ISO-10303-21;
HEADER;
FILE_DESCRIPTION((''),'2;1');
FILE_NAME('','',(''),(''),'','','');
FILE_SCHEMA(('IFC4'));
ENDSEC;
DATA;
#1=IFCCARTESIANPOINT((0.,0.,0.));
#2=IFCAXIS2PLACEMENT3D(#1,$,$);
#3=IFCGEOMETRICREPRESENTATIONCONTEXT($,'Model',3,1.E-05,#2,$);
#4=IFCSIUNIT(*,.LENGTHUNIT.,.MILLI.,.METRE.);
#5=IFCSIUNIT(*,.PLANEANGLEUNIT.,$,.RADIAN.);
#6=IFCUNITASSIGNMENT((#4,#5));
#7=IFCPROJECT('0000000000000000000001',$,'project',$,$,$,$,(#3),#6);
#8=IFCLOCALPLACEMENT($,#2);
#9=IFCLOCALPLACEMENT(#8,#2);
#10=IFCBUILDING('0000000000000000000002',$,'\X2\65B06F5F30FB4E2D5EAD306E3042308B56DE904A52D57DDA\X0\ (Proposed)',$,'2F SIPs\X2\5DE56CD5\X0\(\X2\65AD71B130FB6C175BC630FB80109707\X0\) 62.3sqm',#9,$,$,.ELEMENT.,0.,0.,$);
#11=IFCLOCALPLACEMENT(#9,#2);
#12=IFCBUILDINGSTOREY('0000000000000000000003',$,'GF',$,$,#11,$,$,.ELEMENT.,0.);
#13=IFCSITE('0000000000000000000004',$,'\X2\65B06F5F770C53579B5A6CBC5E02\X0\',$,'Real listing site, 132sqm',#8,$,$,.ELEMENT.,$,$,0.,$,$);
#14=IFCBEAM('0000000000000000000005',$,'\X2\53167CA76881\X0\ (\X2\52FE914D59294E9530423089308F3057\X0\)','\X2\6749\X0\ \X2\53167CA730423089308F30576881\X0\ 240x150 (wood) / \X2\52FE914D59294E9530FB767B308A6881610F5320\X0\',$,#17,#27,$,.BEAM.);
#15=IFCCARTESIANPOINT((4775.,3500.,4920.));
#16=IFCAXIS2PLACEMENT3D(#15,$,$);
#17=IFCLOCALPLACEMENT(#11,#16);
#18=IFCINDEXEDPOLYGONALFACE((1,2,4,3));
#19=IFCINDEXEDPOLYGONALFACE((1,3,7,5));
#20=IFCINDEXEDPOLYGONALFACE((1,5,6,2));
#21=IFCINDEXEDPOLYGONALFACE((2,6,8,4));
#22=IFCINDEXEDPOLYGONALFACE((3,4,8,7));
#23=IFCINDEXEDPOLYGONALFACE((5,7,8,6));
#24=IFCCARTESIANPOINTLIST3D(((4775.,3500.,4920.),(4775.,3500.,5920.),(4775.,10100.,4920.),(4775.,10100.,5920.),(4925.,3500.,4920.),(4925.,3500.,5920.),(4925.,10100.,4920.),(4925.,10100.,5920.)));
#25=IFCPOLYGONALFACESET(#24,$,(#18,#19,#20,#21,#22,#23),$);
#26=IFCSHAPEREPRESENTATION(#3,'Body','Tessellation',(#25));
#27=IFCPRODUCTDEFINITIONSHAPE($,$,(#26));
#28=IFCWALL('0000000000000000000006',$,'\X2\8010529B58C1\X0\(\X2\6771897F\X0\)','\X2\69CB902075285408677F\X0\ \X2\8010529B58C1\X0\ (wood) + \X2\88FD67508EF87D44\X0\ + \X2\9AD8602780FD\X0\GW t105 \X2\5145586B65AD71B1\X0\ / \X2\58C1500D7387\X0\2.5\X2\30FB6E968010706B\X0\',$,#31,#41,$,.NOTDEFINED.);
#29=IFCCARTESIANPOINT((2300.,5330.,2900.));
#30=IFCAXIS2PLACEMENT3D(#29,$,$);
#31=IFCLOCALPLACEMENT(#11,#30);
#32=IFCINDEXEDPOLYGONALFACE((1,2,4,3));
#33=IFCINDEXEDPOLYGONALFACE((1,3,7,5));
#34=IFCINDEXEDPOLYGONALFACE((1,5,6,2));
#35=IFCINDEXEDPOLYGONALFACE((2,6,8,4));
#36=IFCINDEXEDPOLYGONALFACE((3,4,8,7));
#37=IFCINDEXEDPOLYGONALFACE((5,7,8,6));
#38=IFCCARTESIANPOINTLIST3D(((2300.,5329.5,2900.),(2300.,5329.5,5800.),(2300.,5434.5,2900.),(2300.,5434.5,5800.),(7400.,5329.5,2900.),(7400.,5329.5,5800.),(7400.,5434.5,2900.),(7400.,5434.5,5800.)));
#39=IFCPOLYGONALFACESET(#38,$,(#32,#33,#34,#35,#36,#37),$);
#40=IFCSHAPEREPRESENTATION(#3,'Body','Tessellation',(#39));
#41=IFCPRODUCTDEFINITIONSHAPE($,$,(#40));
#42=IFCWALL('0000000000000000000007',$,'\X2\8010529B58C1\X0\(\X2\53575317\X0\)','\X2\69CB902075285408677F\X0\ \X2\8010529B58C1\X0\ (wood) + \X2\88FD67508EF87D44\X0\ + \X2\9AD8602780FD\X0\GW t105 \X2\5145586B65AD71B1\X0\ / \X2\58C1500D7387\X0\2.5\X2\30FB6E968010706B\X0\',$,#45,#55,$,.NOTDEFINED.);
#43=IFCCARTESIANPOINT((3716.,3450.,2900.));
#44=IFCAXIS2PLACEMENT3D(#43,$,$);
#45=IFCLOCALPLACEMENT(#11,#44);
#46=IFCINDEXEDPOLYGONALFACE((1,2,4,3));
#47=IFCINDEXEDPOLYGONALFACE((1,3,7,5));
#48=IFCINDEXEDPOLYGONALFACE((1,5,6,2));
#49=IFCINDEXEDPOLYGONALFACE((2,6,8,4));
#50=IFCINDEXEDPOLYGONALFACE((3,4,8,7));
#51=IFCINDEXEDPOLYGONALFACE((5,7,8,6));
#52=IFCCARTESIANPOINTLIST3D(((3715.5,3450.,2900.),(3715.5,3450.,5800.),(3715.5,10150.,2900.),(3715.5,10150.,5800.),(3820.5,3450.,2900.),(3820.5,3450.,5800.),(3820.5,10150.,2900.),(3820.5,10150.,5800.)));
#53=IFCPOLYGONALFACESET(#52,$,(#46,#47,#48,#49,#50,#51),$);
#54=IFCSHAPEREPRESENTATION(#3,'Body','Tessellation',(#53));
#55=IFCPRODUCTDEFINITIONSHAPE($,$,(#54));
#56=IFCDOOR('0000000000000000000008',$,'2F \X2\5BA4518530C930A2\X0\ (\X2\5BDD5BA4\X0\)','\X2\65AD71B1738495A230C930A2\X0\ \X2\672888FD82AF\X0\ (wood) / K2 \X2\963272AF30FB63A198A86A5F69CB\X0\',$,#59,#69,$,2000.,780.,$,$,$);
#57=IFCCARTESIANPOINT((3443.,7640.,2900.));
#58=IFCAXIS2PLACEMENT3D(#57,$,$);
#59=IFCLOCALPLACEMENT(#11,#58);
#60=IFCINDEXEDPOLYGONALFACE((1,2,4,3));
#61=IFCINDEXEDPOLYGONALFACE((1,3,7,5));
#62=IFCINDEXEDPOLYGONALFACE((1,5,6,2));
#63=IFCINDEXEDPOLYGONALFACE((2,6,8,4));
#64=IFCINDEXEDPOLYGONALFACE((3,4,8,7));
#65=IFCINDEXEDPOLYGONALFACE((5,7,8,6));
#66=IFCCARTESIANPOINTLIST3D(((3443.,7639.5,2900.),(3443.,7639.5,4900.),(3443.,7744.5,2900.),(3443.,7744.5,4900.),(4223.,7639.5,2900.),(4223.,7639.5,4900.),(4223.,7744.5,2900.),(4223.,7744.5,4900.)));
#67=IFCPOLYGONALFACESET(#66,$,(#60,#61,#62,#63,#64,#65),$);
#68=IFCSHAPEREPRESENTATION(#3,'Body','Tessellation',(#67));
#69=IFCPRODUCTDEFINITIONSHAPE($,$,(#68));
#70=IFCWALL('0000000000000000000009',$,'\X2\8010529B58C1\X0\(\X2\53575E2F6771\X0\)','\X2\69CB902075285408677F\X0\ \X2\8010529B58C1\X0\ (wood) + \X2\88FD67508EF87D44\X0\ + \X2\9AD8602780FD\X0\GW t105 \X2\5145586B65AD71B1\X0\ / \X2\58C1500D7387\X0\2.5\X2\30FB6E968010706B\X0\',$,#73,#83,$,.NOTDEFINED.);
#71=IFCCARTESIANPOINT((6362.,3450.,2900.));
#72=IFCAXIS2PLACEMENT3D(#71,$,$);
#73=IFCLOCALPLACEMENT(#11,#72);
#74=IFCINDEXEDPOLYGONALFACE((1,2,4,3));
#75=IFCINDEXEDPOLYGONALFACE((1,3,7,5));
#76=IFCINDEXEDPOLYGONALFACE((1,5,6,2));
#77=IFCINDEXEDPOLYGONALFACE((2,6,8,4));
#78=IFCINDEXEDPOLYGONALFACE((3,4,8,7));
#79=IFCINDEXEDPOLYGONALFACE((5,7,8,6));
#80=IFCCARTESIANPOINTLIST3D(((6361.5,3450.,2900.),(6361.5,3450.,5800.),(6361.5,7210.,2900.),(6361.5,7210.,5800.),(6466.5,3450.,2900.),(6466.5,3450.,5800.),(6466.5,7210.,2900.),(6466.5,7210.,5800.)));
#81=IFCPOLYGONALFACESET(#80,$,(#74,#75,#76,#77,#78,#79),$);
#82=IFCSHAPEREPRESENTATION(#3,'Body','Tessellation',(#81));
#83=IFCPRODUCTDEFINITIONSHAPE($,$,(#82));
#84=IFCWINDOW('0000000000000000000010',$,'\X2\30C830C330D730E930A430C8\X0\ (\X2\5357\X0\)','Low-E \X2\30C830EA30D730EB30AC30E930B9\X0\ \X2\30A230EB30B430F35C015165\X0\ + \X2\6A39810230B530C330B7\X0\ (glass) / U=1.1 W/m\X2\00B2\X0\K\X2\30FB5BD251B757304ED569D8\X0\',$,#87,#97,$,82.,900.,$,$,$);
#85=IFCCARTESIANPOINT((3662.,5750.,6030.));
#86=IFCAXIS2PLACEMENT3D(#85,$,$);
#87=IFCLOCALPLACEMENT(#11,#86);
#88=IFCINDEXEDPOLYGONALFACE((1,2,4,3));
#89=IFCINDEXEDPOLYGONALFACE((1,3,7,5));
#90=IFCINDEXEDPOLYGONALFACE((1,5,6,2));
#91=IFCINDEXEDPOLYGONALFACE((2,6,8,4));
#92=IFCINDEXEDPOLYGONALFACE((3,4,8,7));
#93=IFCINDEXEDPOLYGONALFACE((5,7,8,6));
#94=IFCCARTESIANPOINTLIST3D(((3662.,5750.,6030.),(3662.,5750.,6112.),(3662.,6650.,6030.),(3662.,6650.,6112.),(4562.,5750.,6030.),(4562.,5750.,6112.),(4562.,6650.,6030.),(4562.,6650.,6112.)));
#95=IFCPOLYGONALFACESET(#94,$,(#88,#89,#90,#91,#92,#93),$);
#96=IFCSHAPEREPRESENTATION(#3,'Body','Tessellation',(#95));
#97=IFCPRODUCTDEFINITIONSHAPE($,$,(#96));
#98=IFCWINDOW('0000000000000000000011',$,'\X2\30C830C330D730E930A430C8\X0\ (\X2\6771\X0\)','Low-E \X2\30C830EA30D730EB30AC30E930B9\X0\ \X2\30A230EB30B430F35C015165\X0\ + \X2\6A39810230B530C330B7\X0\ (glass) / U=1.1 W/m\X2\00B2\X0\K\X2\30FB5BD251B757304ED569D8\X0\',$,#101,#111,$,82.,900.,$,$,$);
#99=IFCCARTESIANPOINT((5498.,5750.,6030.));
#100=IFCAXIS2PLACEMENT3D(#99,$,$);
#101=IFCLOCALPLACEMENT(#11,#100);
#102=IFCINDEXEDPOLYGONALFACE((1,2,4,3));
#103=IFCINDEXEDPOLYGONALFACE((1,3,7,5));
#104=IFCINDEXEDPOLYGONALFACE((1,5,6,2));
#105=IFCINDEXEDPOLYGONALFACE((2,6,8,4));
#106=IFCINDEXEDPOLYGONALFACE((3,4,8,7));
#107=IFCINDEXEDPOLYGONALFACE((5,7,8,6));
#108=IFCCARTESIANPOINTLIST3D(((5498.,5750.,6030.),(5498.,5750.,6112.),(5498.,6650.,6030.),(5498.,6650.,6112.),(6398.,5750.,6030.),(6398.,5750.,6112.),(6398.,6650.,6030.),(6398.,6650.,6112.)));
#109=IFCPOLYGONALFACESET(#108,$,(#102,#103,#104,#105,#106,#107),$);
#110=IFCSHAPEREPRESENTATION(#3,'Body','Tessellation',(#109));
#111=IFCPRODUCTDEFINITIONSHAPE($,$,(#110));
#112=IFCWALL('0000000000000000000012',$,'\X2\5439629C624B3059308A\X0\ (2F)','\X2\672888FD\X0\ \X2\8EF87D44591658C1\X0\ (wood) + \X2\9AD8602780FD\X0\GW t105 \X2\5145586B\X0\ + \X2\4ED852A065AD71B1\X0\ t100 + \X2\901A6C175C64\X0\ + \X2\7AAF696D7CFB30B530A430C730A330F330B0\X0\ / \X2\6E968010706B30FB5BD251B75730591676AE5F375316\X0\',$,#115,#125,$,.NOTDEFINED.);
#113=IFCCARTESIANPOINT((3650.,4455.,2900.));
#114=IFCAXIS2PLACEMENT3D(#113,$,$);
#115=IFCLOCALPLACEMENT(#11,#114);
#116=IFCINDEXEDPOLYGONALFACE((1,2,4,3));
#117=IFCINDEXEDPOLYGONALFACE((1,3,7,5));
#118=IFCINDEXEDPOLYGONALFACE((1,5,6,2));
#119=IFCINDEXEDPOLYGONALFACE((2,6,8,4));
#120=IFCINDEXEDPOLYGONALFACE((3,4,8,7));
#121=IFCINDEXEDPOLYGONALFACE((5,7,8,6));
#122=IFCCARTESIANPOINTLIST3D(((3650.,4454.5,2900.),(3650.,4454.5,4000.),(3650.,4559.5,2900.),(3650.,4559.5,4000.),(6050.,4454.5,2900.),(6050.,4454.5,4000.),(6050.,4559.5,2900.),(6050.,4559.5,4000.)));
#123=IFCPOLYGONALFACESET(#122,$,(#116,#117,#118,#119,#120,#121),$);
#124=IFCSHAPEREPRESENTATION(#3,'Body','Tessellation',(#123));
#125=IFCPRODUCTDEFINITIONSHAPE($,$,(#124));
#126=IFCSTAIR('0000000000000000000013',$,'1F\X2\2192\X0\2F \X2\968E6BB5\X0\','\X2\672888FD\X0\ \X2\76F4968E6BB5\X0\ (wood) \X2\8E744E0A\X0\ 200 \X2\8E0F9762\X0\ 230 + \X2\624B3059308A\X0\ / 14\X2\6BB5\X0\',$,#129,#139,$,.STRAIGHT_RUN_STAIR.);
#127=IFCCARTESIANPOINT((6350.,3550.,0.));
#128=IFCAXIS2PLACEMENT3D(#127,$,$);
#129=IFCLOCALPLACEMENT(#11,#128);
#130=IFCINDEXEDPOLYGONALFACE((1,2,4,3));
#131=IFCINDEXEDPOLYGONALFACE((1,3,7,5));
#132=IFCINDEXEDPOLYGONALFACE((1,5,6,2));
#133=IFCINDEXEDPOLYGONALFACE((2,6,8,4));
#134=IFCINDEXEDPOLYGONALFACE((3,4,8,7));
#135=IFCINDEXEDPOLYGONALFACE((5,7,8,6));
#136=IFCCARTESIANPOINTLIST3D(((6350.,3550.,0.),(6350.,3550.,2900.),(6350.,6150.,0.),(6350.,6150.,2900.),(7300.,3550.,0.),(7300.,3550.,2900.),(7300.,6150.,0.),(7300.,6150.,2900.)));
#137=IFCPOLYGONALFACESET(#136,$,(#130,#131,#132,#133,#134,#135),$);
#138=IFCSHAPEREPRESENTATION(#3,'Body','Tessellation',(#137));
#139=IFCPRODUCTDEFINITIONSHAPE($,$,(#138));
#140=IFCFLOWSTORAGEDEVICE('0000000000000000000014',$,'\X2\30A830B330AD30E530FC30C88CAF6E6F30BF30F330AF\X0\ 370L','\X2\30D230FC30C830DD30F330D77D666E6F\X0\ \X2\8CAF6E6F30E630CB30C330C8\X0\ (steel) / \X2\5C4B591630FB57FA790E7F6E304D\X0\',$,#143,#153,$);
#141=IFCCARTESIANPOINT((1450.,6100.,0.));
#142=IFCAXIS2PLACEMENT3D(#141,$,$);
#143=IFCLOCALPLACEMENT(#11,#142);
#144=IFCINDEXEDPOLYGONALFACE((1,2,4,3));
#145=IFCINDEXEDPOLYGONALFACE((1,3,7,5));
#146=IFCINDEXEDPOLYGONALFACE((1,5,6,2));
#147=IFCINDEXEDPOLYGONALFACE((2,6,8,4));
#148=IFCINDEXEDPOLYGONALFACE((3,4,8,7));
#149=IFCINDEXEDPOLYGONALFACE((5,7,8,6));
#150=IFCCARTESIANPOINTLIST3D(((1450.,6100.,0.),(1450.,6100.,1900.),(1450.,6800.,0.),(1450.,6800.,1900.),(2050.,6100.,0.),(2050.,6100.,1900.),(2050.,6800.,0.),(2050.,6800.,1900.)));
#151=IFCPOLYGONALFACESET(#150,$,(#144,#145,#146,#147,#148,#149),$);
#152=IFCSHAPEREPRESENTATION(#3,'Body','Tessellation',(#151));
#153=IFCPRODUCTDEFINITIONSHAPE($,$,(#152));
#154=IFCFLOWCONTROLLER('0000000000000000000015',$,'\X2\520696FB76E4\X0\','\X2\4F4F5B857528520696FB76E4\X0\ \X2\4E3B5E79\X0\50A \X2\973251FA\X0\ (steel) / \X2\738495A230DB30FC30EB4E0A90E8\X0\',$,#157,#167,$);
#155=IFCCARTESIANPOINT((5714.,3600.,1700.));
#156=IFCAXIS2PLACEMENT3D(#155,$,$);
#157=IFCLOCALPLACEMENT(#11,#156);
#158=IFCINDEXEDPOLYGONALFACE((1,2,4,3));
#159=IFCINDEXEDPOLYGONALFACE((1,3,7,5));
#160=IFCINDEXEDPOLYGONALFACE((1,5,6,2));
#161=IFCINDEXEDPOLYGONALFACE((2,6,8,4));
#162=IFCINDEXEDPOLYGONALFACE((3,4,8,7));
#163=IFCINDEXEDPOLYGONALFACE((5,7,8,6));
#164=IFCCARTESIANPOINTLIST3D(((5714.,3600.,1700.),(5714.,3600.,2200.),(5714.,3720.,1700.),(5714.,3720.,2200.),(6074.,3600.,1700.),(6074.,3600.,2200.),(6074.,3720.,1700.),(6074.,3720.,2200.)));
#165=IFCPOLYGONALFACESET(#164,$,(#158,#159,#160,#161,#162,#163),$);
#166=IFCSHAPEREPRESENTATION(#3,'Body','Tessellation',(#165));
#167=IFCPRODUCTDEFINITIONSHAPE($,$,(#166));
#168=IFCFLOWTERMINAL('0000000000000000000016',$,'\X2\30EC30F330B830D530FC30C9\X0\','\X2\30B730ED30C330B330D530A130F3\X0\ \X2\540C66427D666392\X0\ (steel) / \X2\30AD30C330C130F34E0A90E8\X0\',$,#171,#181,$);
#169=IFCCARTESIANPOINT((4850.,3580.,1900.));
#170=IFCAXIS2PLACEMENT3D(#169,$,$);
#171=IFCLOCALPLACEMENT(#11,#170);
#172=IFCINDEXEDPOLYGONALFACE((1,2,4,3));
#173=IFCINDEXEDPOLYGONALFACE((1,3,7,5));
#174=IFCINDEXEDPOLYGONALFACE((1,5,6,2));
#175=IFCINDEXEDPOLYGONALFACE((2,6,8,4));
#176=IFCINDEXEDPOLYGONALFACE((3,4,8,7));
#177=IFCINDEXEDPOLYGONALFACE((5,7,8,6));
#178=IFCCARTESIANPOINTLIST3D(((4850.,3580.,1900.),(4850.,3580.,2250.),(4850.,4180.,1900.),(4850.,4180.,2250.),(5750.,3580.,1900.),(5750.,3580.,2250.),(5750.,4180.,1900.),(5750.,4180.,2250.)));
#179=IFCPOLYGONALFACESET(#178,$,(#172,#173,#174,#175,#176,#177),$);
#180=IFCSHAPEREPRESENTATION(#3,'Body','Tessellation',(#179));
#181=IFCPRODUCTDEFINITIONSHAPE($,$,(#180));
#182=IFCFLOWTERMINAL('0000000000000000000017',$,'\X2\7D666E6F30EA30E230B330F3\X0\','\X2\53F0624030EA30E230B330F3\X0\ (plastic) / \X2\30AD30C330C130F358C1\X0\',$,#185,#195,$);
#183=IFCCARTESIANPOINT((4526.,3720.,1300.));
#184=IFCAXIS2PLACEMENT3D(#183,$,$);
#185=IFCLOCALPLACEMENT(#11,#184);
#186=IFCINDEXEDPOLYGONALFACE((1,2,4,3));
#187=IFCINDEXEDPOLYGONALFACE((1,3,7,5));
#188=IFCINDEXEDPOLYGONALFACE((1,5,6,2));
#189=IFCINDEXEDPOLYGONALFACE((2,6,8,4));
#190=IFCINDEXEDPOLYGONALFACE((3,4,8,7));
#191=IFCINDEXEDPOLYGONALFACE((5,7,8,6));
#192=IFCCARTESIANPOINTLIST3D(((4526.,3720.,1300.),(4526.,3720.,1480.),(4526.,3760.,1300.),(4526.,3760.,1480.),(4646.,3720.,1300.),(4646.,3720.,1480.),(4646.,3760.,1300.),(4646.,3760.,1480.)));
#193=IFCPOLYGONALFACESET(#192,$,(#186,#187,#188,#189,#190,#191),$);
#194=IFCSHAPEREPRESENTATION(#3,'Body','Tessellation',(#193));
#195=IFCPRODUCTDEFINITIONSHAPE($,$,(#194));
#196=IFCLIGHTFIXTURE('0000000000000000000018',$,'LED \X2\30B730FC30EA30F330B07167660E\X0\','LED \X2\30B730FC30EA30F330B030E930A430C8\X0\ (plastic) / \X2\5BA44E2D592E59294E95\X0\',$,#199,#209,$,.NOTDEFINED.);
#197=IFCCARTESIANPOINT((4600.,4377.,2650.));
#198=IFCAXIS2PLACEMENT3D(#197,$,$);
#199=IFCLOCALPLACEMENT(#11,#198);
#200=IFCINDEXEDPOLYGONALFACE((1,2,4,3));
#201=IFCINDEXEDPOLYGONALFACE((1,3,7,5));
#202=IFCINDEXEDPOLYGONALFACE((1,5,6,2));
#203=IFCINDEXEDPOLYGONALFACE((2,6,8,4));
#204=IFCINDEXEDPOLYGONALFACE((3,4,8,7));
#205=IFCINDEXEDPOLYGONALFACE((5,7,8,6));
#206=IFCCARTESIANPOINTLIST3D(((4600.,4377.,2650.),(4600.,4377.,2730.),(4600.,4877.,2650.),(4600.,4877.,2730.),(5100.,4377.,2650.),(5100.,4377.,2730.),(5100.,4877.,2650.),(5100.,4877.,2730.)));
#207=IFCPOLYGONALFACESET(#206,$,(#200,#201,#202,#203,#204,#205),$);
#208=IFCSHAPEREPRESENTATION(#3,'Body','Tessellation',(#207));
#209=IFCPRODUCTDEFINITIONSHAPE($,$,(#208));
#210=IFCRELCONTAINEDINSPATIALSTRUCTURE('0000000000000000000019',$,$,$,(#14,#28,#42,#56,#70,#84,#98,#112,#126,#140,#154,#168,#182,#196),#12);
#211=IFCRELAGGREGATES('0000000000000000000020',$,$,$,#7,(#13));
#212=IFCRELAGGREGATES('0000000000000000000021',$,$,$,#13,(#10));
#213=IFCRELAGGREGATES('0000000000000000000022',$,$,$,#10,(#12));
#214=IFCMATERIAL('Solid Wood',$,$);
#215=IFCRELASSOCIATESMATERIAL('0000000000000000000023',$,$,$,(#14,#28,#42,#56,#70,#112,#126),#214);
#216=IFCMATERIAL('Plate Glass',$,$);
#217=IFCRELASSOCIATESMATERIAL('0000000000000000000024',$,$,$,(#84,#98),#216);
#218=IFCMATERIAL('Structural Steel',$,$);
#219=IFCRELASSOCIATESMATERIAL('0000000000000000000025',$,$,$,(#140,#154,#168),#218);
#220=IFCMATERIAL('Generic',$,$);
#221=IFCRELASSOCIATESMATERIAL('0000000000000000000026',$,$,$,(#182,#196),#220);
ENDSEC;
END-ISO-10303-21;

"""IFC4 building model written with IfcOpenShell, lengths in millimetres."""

from ifc_helpers import new_model, si_unit, frame, frame_2d, origin, place, context, project, spatial, rectangle, extrude, material, element, fill, save


model = new_model("IFC4")

# Units and contexts
model_context = context("Model", 3, precision=1e-05, world=origin())
ifc_project = project(units=[si_unit("LENGTHUNIT", "METRE", prefix="MILLI"), si_unit("PLANEANGLEUNIT", "RADIAN")], contexts=[model_context])

# Site, building, storey
site_placement = place(None, origin())
site = spatial("IfcSite", under=ifc_project, at=site_placement, Name="新潟県南魚沼市", ObjectType="Real listing site, 132sqm", CompositionType="ELEMENT", RefElevation=0.0)
building_placement = place(site_placement, origin())
building = spatial("IfcBuilding", under=site, at=building_placement, Name="新潟・中庭のある回遊動線 (Proposed)", ObjectType="2F SIPs工法(断熱・気密・耐震) 62.3sqm", CompositionType="ELEMENT", ElevationOfRefHeight=0.0, ElevationOfTerrain=0.0)
storey_placement = place(building_placement, origin())
storey = spatial("IfcBuildingStorey", under=building, at=storey_placement, Name="GF", CompositionType="ELEMENT", Elevation=0.0)

# Shared definitions
ifc_material_1 = material(Name="Solid Wood")

# Beam
beam_placement = place(storey_placement, frame((4775.0, 3500.0, 4920.0)))
element("IfcBeam", 1, at=beam_placement, inside=storey, material=ifc_material_1, Name="化粧梁 (勾配天井あらわし)", Description="杉 化粧あらわし梁 240x150 (wood) / 勾配天井・登り梁意匠", PredefinedType="BEAM", context=model_context, shape_type="SweptSolid", body=[
    extrude(rectangle(XDim=150.0, YDim=6600.0, at=frame_2d((75.0, 3300.0))), frame((4775.0, 3500.0, 4920.0)), (0.0, 0.0, 1.0), 1000.0),
])

# Wall
wall_1_placement = place(storey_placement, frame((2300.0, 5330.0, 2900.0)))
element("IfcWall", 2, at=wall_1_placement, inside=storey, material=ifc_material_1, Name="耐力壁(東西)", Description="構造用合板 耐力壁 (wood) + 製材軸組 + 高性能GW t105 充填断熱 / 壁倍率2.5・準耐火", PredefinedType="NOTDEFINED", context=model_context, shape_type="SweptSolid", body=[
    extrude(rectangle(XDim=5100.0, YDim=105.0, at=frame_2d((2550.0, 52.0))), frame((2300.0, 5330.0, 2900.0)), (0.0, 0.0, 1.0), 2900.0),
])

# Wall, opening, door
wall_2_placement = place(storey_placement, frame((3716.0, 3450.0, 2900.0)))
wall_2 = element("IfcWall", 3, at=wall_2_placement, inside=storey, material=ifc_material_1, Name="耐力壁(南北)", Description="構造用合板 耐力壁 (wood) + 製材軸組 + 高性能GW t105 充填断熱 / 壁倍率2.5・準耐火", PredefinedType="NOTDEFINED", context=model_context, shape_type="SweptSolid", body=[
    extrude(rectangle(XDim=105.0, YDim=6700.0, at=frame_2d((52.0, 3350.0))), frame((3716.0, 3450.0, 2900.0)), (0.0, 0.0, 1.0), 2900.0),
])
opening_placement = place(storey_placement, frame((3443.0, 7640.0, 2900.0)))
opening = element("IfcOpeningElement", 4, at=opening_placement, cuts=wall_2, PredefinedType="NOTDEFINED", context=model_context, shape_type="SweptSolid", body=[
    extrude(rectangle(XDim=780.0, YDim=105.0, at=frame_2d((390.0, 52.0))), frame((3443.0, 7640.0, 2900.0)), (0.0, 0.0, 1.0), 2000.0),
])
door_placement = place(storey_placement, frame((3443.0, 7640.0, 2900.0)))
door = element("IfcDoor", 5, at=door_placement, inside=storey, material=ifc_material_1, Name="2F 室内ドア (寝室)", Description="断熱玄関ドア 木製芯 (wood) / K2 防犯・採風機構", OverallHeight=2000.0, OverallWidth=780.0, context=model_context, shape_type="SweptSolid", body=[
    extrude(rectangle(XDim=780.0, YDim=105.0, at=frame_2d((390.0, 52.0))), frame((3443.0, 7640.0, 2900.0)), (0.0, 0.0, 1.0), 2000.0),
])
fill(opening, door)

# Wall
wall_3_placement = place(storey_placement, frame((6362.0, 3450.0, 2900.0)))
element("IfcWall", 6, at=wall_3_placement, inside=storey, material=ifc_material_1, Name="耐力壁(南帯東)", Description="構造用合板 耐力壁 (wood) + 製材軸組 + 高性能GW t105 充填断熱 / 壁倍率2.5・準耐火", PredefinedType="NOTDEFINED", context=model_context, shape_type="SweptSolid", body=[
    extrude(rectangle(XDim=105.0, YDim=3760.0, at=frame_2d((52.0, 1880.0))), frame((6362.0, 3450.0, 2900.0)), (0.0, 0.0, 1.0), 2900.0),
])

# Windows
ifc_material_2 = material(Name="Plate Glass")
window_1_placement = place(storey_placement, frame((3662.0, 5750.0, 6030.0)))
element("IfcWindow", 7, at=window_1_placement, inside=storey, material=ifc_material_2, Name="トップライト (南)", Description="Low-E トリプルガラス アルゴン封入 + 樹脂サッシ (glass) / U=1.1 W/m²K・寒冷地仕様", OverallHeight=82.0, OverallWidth=900.0, context=model_context, shape_type="SweptSolid", body=[
    extrude(rectangle(XDim=900.0, YDim=900.0, at=frame_2d((450.0, 450.0))), frame((3662.0, 5750.0, 6030.0)), (0.0, 0.0, 1.0), 82.0),
])
window_2_placement = place(storey_placement, frame((5498.0, 5750.0, 6030.0)))
element("IfcWindow", 8, at=window_2_placement, inside=storey, material=ifc_material_2, Name="トップライト (東)", Description="Low-E トリプルガラス アルゴン封入 + 樹脂サッシ (glass) / U=1.1 W/m²K・寒冷地仕様", OverallHeight=82.0, OverallWidth=900.0, context=model_context, shape_type="SweptSolid", body=[
    extrude(rectangle(XDim=900.0, YDim=900.0, at=frame_2d((450.0, 450.0))), frame((5498.0, 5750.0, 6030.0)), (0.0, 0.0, 1.0), 82.0),
])

# Wall
wall_4_placement = place(storey_placement, frame((3650.0, 4455.0, 2900.0)))
element("IfcWall", 9, at=wall_4_placement, inside=storey, material=ifc_material_1, Name="吹抜手すり (2F)", Description="木製 軸組外壁 (wood) + 高性能GW t105 充填 + 付加断熱 t100 + 通気層 + 窯業系サイディング / 準耐火・寒冷地外皮強化", PredefinedType="NOTDEFINED", context=model_context, shape_type="SweptSolid", body=[
    extrude(rectangle(XDim=2400.0, YDim=105.0, at=frame_2d((1200.0, 52.0))), frame((3650.0, 4455.0, 2900.0)), (0.0, 0.0, 1.0), 1100.0),
])

# Stair
stair_placement = place(storey_placement, frame((6350.0, 3550.0, 0.0)))
element("IfcStair", 10, at=stair_placement, inside=storey, material=ifc_material_1, Name="1F→2F 階段", Description="木製 直階段 (wood) 蹴上 200 踏面 230 + 手すり / 14段", PredefinedType="STRAIGHT_RUN_STAIR", context=model_context, shape_type="SweptSolid", body=[
    extrude(rectangle(XDim=950.0, YDim=2600.0, at=frame_2d((475.0, 1300.0))), frame((6350.0, 3550.0, 0.0)), (0.0, 0.0, 1.0), 2900.0),
])

# Flow storage device
ifc_material_3 = material(Name="Structural Steel")
flow_storage_device_placement = place(storey_placement, frame((1450.0, 6100.0, 0.0)))
element("IfcFlowStorageDevice", 11, at=flow_storage_device_placement, inside=storey, material=ifc_material_3, Name="エコキュート貯湯タンク 370L", Description="ヒートポンプ給湯 貯湯ユニット (steel) / 屋外・基礎置き", context=model_context, shape_type="SweptSolid", body=[
    extrude(rectangle(XDim=600.0, YDim=700.0, at=frame_2d((300.0, 350.0))), frame((1450.0, 6100.0, 0.0)), (0.0, 0.0, 1.0), 1900.0),
])

# Flow controller
flow_controller_placement = place(storey_placement, frame((5714.0, 3600.0, 1700.0)))
element("IfcFlowController", 12, at=flow_controller_placement, inside=storey, material=ifc_material_3, Name="分電盤", Description="住宅用分電盤 主幹50A 露出 (steel) / 玄関ホール上部", context=model_context, shape_type="SweptSolid", body=[
    extrude(rectangle(XDim=360.0, YDim=120.0, at=frame_2d((180.0, 60.0))), frame((5714.0, 3600.0, 1700.0)), (0.0, 0.0, 1.0), 500.0),
])

# Flow terminals
flow_terminal_1_placement = place(storey_placement, frame((4850.0, 3580.0, 1900.0)))
element("IfcFlowTerminal", 13, at=flow_terminal_1_placement, inside=storey, material=ifc_material_3, Name="レンジフード", Description="シロッコファン 同時給排 (steel) / キッチン上部", context=model_context, shape_type="SweptSolid", body=[
    extrude(rectangle(XDim=900.0, YDim=600.0, at=frame_2d((450.0, 300.0))), frame((4850.0, 3580.0, 1900.0)), (0.0, 0.0, 1.0), 350.0),
])
ifc_material_4 = material(Name="Generic")
flow_terminal_2_placement = place(storey_placement, frame((4526.0, 3720.0, 1300.0)))
element("IfcFlowTerminal", 14, at=flow_terminal_2_placement, inside=storey, material=ifc_material_4, Name="給湯リモコン", Description="台所リモコン (plastic) / キッチン壁", context=model_context, shape_type="SweptSolid", body=[
    extrude(rectangle(XDim=120.0, YDim=40.0, at=frame_2d((60.0, 20.0))), frame((4526.0, 3720.0, 1300.0)), (0.0, 0.0, 1.0), 180.0),
])

# Light fixture
light_fixture_1_placement = place(storey_placement, frame((4600.0, 4377.0, 2650.0)))
element("IfcLightFixture", 15, at=light_fixture_1_placement, inside=storey, material=ifc_material_4, Name="LED シーリング照明", Description="LED シーリングライト (plastic) / 室中央天井", PredefinedType="NOTDEFINED", context=model_context, shape_type="SweptSolid", body=[
    extrude(rectangle(XDim=500.0, YDim=500.0, at=frame_2d((250.0, 250.0))), frame((4600.0, 4377.0, 2650.0)), (0.0, 0.0, 1.0), 80.0),
])

save(model, "model.ifc")
